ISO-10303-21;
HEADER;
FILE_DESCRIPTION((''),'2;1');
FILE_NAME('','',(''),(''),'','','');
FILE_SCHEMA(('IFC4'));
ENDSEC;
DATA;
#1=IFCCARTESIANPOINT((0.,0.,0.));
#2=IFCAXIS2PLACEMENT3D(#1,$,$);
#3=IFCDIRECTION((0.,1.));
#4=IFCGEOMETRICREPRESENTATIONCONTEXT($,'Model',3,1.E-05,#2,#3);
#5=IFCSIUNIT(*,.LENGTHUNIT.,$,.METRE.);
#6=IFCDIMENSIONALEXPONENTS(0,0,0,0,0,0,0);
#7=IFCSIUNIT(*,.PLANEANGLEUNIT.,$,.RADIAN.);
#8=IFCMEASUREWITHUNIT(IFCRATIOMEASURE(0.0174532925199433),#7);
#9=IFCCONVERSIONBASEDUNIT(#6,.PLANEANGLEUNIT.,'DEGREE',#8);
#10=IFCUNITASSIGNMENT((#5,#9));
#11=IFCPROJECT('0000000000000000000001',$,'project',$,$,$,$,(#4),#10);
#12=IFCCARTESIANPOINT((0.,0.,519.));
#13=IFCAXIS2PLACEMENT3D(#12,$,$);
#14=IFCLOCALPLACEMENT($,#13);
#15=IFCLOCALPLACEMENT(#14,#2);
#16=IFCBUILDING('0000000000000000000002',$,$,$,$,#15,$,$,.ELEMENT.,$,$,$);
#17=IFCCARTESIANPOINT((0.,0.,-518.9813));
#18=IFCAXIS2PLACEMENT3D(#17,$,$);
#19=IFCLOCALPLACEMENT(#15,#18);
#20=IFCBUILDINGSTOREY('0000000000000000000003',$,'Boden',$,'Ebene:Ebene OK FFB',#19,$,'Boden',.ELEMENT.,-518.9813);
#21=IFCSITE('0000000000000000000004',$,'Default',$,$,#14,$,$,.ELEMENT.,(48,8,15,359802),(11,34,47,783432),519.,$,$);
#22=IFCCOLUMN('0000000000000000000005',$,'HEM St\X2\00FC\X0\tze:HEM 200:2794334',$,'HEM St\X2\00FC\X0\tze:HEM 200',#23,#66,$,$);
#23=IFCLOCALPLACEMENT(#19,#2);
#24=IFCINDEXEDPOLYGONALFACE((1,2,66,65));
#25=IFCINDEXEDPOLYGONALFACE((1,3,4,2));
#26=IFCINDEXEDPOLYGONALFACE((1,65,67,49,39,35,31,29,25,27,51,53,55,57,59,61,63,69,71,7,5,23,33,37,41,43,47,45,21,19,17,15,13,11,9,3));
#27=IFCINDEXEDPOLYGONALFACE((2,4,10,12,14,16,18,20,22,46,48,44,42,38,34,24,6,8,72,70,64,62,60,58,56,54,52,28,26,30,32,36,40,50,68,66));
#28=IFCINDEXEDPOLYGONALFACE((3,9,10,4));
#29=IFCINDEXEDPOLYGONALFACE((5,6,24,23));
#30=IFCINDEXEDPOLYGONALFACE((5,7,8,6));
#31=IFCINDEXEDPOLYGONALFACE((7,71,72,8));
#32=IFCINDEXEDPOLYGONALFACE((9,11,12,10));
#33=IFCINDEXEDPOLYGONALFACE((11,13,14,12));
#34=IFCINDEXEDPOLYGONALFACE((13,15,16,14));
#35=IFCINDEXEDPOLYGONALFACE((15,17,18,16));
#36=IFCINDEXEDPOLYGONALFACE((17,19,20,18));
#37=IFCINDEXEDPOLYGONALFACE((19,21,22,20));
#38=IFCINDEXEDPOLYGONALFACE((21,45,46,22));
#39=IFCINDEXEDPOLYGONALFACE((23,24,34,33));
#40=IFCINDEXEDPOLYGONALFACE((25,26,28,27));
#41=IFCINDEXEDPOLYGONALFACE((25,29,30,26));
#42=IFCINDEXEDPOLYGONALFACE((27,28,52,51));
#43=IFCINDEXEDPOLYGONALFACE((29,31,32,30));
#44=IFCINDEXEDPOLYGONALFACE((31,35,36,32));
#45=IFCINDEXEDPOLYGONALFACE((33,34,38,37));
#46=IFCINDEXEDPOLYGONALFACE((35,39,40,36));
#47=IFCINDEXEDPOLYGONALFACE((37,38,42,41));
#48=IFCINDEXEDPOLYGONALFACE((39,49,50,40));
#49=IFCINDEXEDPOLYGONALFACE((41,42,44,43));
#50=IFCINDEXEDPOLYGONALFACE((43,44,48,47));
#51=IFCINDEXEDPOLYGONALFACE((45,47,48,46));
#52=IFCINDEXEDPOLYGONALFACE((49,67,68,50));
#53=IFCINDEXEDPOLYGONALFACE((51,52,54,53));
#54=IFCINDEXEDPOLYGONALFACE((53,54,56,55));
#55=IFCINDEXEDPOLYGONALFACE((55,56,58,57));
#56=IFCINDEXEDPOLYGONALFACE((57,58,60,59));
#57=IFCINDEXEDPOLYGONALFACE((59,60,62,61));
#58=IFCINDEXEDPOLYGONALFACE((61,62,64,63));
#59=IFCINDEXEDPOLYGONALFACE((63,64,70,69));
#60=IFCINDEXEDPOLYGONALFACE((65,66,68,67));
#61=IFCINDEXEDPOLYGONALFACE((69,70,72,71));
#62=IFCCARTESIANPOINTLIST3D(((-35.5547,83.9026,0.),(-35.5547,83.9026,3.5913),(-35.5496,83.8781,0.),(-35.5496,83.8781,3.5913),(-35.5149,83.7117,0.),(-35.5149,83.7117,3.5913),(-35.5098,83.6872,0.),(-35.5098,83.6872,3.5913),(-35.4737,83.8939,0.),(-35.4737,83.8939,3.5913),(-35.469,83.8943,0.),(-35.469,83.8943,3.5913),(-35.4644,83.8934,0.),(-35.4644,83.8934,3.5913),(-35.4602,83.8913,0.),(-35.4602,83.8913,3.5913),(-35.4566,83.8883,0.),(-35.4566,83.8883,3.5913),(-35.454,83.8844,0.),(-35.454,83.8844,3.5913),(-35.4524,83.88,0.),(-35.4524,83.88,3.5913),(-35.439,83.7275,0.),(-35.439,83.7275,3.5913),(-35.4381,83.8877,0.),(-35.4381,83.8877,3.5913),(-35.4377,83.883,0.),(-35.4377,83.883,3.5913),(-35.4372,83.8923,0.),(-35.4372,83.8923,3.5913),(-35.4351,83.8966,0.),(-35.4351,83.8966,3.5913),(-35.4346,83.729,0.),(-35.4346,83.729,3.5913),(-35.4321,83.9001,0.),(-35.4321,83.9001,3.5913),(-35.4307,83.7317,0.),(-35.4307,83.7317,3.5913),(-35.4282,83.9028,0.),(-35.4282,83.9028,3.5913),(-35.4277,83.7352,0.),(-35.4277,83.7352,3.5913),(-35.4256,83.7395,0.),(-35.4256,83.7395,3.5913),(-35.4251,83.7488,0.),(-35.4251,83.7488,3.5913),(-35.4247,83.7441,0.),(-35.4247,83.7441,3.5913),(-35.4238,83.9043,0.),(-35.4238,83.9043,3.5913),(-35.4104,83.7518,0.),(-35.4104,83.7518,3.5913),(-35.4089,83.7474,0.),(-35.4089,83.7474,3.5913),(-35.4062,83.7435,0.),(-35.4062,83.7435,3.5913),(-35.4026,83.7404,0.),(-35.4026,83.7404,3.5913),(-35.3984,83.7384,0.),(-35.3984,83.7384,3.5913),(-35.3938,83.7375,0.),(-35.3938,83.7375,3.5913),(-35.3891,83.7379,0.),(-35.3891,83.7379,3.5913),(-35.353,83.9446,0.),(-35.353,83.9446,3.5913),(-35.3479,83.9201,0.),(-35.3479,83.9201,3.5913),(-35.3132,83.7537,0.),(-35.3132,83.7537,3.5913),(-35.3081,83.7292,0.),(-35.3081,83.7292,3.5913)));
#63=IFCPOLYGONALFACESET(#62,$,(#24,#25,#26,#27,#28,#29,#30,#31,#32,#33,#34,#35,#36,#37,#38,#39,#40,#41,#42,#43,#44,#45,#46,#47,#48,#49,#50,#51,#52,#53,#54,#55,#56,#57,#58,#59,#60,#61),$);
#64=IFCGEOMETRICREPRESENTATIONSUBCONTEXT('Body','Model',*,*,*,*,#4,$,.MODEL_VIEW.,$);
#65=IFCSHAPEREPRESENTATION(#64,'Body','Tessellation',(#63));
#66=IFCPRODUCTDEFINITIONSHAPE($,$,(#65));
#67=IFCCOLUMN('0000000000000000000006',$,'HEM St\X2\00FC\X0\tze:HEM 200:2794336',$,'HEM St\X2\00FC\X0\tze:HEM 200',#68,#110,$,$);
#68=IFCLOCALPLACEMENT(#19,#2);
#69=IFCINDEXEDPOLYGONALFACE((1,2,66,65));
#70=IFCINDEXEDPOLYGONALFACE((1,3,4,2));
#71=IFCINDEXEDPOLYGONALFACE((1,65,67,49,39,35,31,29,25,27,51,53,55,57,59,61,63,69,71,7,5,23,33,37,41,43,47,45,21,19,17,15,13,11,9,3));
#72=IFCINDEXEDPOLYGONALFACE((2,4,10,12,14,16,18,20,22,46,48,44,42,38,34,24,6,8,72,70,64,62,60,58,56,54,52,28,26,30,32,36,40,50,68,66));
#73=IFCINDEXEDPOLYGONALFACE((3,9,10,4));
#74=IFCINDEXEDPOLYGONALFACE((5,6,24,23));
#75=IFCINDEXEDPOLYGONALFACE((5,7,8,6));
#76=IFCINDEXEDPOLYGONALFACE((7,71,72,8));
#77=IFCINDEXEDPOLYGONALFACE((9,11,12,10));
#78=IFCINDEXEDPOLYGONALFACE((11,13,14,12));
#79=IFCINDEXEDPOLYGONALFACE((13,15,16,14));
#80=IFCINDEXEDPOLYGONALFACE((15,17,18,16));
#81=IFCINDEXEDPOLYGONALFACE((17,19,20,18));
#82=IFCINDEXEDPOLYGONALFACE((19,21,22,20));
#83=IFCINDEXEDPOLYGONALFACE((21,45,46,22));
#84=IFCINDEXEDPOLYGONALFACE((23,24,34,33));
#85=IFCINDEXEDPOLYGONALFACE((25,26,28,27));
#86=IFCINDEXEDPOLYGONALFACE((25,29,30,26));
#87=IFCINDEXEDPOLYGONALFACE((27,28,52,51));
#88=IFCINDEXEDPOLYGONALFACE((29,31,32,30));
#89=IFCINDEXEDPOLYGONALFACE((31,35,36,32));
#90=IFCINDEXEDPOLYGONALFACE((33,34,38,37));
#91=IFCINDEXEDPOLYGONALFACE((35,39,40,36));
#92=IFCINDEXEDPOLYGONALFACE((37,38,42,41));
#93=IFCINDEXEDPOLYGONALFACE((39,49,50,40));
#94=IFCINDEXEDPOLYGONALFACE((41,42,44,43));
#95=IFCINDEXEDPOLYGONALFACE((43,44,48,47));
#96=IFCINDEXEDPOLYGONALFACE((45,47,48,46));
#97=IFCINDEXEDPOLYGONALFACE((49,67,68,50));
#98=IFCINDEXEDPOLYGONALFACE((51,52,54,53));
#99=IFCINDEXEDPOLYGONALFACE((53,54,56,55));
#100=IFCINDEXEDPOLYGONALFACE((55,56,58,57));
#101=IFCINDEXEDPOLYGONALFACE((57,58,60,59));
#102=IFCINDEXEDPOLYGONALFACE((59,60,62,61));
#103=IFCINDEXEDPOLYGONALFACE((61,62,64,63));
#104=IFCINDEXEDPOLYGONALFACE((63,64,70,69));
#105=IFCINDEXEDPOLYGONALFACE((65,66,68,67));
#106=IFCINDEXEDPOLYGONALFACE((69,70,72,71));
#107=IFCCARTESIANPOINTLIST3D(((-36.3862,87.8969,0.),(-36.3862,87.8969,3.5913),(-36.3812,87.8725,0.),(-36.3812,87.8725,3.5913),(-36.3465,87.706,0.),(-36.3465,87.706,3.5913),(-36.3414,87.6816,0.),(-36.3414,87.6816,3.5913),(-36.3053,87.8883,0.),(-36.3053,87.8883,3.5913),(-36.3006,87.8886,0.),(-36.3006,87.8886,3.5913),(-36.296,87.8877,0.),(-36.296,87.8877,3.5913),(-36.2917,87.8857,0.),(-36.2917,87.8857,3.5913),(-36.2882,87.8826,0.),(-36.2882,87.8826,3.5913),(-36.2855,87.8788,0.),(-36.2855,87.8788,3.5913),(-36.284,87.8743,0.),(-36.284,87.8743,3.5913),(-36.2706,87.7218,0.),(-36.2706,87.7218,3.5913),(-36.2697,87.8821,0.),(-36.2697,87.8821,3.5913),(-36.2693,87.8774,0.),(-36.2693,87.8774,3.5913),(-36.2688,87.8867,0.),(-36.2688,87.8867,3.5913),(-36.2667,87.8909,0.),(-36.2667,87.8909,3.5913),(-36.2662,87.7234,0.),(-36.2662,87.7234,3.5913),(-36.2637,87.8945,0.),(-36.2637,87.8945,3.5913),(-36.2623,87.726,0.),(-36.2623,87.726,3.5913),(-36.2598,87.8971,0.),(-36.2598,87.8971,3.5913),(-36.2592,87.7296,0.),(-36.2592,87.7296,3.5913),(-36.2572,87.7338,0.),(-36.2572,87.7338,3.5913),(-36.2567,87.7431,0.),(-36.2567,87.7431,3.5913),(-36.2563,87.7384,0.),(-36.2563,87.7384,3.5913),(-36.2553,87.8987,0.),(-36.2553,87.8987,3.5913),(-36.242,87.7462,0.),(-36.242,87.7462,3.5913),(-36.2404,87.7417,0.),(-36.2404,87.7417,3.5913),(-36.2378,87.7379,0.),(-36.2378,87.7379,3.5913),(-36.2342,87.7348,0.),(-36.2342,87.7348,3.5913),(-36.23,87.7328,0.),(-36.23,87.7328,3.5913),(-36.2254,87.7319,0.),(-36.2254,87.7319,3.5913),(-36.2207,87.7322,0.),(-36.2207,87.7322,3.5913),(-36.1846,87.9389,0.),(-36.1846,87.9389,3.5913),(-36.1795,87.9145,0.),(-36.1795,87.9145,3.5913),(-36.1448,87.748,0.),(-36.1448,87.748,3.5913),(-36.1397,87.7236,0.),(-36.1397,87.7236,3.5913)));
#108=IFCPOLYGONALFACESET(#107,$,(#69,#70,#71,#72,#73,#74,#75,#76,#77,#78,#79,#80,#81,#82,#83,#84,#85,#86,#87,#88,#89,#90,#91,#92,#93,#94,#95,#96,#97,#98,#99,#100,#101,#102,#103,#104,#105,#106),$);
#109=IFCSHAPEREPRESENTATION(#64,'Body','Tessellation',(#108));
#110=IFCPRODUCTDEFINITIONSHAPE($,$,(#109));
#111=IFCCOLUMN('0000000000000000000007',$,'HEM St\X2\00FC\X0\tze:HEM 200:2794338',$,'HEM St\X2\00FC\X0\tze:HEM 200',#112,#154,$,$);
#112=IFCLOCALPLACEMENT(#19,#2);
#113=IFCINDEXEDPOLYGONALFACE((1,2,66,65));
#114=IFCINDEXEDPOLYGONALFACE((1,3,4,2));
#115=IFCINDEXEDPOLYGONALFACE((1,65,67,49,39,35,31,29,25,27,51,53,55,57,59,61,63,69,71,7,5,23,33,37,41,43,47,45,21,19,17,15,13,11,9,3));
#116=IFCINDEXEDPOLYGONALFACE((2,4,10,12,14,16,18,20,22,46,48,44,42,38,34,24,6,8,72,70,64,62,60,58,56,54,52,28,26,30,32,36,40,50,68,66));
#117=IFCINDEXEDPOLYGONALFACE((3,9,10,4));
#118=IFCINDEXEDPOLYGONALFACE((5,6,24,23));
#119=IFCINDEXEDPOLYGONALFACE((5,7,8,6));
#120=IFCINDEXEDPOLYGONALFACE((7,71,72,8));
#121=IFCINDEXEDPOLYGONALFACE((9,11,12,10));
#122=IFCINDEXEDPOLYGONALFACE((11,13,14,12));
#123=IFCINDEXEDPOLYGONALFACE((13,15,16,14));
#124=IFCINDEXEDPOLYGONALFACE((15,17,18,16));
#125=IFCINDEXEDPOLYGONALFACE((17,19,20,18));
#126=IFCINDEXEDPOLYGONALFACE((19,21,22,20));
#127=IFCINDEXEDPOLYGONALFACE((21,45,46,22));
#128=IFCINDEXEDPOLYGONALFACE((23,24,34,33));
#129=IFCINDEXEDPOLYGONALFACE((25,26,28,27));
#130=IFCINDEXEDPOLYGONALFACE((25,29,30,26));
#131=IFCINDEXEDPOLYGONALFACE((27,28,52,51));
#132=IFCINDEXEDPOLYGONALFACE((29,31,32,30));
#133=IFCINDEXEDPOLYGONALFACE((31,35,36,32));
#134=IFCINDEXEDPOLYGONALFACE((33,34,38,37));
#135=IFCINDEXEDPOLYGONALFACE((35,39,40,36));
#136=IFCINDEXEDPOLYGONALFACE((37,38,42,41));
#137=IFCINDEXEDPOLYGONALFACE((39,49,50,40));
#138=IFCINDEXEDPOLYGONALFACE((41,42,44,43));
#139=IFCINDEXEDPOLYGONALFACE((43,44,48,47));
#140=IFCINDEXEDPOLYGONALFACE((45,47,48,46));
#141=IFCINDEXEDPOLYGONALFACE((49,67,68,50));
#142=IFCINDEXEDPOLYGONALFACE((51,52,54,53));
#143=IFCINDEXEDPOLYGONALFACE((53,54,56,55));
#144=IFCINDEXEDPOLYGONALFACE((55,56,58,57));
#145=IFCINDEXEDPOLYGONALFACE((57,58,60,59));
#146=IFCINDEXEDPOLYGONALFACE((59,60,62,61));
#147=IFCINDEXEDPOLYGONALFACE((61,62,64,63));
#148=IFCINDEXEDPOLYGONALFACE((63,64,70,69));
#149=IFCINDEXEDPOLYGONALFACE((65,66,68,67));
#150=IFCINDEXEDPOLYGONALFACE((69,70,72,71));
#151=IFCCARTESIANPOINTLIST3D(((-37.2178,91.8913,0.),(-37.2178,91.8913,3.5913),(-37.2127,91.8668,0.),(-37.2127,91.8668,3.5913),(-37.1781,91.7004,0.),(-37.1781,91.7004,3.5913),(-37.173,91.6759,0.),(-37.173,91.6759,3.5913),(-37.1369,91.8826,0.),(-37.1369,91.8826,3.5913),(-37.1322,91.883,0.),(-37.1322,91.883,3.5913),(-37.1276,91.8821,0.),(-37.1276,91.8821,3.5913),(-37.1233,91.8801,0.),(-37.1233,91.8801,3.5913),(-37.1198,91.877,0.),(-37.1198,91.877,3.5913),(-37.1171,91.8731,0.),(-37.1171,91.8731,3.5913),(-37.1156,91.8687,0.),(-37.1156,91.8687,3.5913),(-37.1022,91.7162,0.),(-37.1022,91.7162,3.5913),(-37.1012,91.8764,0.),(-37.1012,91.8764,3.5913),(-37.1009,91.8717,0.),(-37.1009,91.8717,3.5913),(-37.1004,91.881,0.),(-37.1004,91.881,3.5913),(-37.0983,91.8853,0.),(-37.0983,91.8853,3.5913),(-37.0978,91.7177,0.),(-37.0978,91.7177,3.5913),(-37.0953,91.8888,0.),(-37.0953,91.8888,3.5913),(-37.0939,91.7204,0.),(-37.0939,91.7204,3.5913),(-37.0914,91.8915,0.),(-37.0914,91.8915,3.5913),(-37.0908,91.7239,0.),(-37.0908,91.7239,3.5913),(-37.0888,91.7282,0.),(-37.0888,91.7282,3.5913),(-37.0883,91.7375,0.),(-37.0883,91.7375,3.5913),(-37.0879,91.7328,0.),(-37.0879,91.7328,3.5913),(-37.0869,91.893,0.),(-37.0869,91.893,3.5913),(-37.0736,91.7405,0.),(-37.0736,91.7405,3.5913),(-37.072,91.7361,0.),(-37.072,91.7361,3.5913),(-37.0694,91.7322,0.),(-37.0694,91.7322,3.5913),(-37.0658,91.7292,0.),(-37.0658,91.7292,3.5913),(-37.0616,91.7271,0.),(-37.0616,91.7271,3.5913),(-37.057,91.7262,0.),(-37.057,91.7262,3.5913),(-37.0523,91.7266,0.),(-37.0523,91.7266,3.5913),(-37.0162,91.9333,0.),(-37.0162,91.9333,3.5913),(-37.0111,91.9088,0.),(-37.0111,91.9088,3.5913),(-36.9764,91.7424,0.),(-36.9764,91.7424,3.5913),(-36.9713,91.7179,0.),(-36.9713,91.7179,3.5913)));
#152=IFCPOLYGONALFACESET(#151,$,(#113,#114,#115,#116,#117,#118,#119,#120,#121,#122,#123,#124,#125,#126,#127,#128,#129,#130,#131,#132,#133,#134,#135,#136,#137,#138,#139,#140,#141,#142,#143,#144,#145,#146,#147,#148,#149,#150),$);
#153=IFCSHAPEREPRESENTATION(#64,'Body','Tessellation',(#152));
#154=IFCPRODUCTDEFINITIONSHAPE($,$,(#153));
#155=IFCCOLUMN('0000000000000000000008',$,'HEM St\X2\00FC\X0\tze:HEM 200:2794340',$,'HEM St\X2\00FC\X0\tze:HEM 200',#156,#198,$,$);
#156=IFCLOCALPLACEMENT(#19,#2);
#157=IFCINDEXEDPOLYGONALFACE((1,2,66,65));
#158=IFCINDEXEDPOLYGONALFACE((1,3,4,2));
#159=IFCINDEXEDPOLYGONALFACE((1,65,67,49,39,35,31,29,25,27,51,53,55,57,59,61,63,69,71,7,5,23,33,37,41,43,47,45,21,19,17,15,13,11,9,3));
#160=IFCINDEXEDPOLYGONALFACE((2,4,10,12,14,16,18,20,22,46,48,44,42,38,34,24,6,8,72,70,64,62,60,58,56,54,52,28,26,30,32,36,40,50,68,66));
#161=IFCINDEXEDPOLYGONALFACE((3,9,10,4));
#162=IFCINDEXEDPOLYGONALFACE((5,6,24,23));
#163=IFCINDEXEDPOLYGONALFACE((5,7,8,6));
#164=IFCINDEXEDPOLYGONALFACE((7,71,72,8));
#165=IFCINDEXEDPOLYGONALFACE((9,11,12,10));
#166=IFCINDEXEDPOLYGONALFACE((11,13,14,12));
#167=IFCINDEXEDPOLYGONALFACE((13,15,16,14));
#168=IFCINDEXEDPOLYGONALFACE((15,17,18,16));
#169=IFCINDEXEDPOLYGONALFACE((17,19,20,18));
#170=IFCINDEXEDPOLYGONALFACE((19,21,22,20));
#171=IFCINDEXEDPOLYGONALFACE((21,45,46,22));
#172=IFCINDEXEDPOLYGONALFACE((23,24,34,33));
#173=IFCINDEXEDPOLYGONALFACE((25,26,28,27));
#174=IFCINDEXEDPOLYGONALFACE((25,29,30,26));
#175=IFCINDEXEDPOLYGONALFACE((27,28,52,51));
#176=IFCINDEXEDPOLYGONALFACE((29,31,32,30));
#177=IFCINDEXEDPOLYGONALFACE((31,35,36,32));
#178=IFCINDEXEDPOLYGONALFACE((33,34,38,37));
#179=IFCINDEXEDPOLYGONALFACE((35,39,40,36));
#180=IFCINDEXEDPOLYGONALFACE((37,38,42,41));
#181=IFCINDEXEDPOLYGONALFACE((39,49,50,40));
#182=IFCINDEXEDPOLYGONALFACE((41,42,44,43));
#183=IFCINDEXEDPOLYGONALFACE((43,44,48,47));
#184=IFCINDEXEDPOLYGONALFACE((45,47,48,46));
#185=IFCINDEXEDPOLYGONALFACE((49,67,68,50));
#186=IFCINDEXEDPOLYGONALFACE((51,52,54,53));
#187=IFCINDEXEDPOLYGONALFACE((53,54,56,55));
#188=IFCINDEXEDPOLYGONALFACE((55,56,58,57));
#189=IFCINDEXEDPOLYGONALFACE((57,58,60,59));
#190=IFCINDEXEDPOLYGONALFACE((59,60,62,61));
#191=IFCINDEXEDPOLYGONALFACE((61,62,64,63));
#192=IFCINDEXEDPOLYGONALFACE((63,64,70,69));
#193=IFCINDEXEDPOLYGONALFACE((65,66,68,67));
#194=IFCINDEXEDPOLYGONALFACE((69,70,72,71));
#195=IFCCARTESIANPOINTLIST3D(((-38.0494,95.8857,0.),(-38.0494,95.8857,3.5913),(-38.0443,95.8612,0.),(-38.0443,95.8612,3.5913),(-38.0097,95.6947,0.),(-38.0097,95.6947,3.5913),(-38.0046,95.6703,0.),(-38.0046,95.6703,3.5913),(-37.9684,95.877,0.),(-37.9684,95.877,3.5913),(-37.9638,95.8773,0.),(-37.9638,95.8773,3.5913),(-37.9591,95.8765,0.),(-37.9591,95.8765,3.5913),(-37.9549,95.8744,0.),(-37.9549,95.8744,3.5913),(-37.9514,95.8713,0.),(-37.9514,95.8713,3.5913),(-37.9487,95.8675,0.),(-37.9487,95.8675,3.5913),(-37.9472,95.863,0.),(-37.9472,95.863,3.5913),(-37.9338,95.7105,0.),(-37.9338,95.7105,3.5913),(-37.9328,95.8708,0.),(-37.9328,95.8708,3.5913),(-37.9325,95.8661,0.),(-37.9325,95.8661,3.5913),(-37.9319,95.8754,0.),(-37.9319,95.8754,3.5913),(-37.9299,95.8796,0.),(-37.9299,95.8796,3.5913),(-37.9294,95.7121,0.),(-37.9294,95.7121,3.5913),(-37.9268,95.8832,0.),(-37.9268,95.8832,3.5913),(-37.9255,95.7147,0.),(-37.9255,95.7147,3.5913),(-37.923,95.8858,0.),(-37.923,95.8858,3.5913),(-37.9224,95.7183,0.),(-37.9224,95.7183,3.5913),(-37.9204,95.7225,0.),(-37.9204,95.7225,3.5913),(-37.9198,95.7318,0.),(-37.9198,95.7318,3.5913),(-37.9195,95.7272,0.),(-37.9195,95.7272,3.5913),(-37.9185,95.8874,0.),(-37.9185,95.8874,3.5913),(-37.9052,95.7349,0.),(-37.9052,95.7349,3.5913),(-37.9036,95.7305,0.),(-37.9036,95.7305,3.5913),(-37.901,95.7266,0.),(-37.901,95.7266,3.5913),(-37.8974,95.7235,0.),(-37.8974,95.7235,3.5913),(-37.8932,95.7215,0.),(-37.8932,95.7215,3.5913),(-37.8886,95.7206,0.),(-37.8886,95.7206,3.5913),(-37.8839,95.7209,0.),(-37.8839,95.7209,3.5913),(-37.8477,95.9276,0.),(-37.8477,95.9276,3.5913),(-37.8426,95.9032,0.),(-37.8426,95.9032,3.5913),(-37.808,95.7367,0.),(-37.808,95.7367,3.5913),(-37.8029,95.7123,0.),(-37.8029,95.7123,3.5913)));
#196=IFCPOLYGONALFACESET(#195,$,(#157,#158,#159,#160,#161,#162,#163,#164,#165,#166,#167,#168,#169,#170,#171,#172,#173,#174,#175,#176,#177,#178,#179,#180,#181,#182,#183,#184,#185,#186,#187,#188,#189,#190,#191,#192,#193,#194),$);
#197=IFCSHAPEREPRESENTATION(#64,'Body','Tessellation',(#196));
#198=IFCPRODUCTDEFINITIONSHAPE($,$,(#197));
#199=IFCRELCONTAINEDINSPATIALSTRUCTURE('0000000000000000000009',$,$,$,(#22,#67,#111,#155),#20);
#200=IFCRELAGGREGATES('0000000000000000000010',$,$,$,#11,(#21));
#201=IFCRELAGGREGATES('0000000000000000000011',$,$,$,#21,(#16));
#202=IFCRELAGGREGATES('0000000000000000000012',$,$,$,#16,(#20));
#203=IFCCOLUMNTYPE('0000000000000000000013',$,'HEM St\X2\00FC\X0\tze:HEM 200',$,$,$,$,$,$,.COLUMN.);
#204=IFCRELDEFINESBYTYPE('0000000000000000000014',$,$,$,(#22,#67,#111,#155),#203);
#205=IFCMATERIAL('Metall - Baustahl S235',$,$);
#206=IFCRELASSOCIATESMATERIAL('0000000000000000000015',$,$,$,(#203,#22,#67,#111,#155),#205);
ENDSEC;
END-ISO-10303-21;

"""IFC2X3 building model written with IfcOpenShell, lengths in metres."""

from ifc_helpers import new_model, entity, si_unit, converted_unit, direction, frame, frame_2d, origin, place, context, subcontext, project, spatial, polyline, circle_curve, parameter, trimmed, segment, composite_curve, outline, extrude, source, transform, mapped, material, type_object, type_shapes, element, save


model = new_model("IFC2X3")

# Units and contexts
model_context = context("Model", 3, precision=1e-05, world=origin(), true_north=direction((0.0, 1.0)))
body_context = subcontext(model_context, "Body", "Model", "MODEL_VIEW")
ifc_project = project(units=[si_unit("LENGTHUNIT", "METRE"), converted_unit("PLANEANGLEUNIT", "DEGREE", entity("IfcRatioMeasure", 0.0174532925199433), si_unit("PLANEANGLEUNIT", "RADIAN"), dimensions=[0, 0, 0, 0, 0, 0, 0])], contexts=[model_context])

# Site, building, storey
site_placement = place(None, frame((0.0, 0.0, 519.0)))
site = spatial("IfcSite", under=ifc_project, at=site_placement, Name="Default", CompositionType="ELEMENT", RefLatitude=(48, 8, 15, 359802), RefLongitude=(11, 34, 47, 783432), RefElevation=519.0)
building_placement = place(site_placement, origin())
building = spatial("IfcBuilding", under=site, at=building_placement, CompositionType="ELEMENT")
storey_placement = place(building_placement, frame((0.0, 0.0, -518.9813)))
storey = spatial("IfcBuildingStorey", under=building, at=storey_placement, Name="Boden", ObjectType="Ebene:Ebene OK FFB", LongName="Boden", CompositionType="ELEMENT", Elevation=-518.9813)

# Columns
ifc_material = material(Name="Metall - Baustahl S235")
column_type = type_object("IfcColumnType", Name="HEM Stütze:HEM 200", PredefinedType="COLUMN", material=ifc_material)
shared_shape = source(origin(), body_context, "Body", "SweptSolid", [
    extrude(outline(composite_curve([segment(polyline([(0.085, -0.103), (0.11, -0.103)]), True, "CONTINUOUS"), segment(polyline([(0.11, -0.103), (0.11, 0.103)]), True, "CONTINUOUS"), segment(polyline([(0.11, 0.103), (0.085, 0.103)]), True, "CONTINUOUS"), segment(polyline([(0.085, 0.103), (0.085, 0.0255)]), True, "CONTINUOUS"), segment(trimmed(circle_curve(frame_2d((0.067, 0.0255), x_axis=(1.0, 0.0)), 0.018), [parameter(270.0)], [parameter(0.0)], True, "PARAMETER"), False, "CONTINUOUS"), segment(polyline([(0.067, 0.0075), (-0.067, 0.0075)]), True, "CONTINUOUS"), segment(trimmed(circle_curve(frame_2d((-0.067, 0.0255), x_axis=(0.0, -1.0)), 0.018), [parameter(270.0)], [parameter(0.0)], True, "PARAMETER"), False, "CONTINUOUS"), segment(polyline([(-0.085, 0.0255), (-0.085, 0.103)]), True, "CONTINUOUS"), segment(polyline([(-0.085, 0.103), (-0.11, 0.103)]), True, "CONTINUOUS"), segment(polyline([(-0.11, 0.103), (-0.11, -0.103)]), True, "CONTINUOUS"), segment(polyline([(-0.11, -0.103), (-0.085, -0.103)]), True, "CONTINUOUS"), segment(polyline([(-0.085, -0.103), (-0.085, -0.0255)]), True, "CONTINUOUS"), segment(trimmed(circle_curve(frame_2d((-0.067, -0.0255), x_axis=(-1.0, 0.0)), 0.018), [parameter(270.0)], [parameter(0.0)], True, "PARAMETER"), False, "CONTINUOUS"), segment(polyline([(-0.067, -0.0075), (0.067, -0.0075)]), True, "CONTINUOUS"), segment(trimmed(circle_curve(frame_2d((0.067, -0.0255), x_axis=(0.0, 1.0)), 0.018), [parameter(270.0)], [parameter(0.0)], True, "PARAMETER"), False, "CONTINUOUS"), segment(polyline([(0.085, -0.0255), (0.085, -0.103)]), True, "CONTINUOUS")], self_intersect=False)), frame((0.0, 0.0, -518.9813), z_axis=(0.0, 0.0, 1.0), x_axis=(0.0, -1.0, 0.0)), (0.0, 0.0, 1.0), 3.5913),
])
type_shapes(column_type, [shared_shape])
for number, where, z_axis, x_axis, name in (
    (1, (-35.4314, 83.8159, 518.9813), (0.0, 0.0, 1.0), (0.979008, 0.20382, 0.0), "HEM Stütze:HEM 200:2794334"),
    (2, (-36.263, 87.8103, 518.9813), (0.0, 0.0, 1.0), (0.979008, 0.20382, 0.0), "HEM Stütze:HEM 200:2794336"),
    (3, (-37.0946, 91.8046, 518.9813), (0.0, 0.0, 1.0), (0.979008, 0.20382, 0.0), "HEM Stütze:HEM 200:2794338"),
    (4, (-37.9262, 95.799, 518.9813), (0.0, 0.0, 1.0), (0.979008, 0.20382, 0.0), "HEM Stütze:HEM 200:2794340"),
):
    element("IfcColumn", number, at=place(storey_placement, frame(where, z_axis=z_axis, x_axis=x_axis)), inside=storey, type_object=column_type, material=ifc_material, Name=name, ObjectType="HEM Stütze:HEM 200", context=body_context, shape_type="MappedRepresentation", body=[
        mapped(shared_shape, transform((0.0, 0.0, 0.0), scale=1.0)),
    ])

save(model, "model.ifc")
